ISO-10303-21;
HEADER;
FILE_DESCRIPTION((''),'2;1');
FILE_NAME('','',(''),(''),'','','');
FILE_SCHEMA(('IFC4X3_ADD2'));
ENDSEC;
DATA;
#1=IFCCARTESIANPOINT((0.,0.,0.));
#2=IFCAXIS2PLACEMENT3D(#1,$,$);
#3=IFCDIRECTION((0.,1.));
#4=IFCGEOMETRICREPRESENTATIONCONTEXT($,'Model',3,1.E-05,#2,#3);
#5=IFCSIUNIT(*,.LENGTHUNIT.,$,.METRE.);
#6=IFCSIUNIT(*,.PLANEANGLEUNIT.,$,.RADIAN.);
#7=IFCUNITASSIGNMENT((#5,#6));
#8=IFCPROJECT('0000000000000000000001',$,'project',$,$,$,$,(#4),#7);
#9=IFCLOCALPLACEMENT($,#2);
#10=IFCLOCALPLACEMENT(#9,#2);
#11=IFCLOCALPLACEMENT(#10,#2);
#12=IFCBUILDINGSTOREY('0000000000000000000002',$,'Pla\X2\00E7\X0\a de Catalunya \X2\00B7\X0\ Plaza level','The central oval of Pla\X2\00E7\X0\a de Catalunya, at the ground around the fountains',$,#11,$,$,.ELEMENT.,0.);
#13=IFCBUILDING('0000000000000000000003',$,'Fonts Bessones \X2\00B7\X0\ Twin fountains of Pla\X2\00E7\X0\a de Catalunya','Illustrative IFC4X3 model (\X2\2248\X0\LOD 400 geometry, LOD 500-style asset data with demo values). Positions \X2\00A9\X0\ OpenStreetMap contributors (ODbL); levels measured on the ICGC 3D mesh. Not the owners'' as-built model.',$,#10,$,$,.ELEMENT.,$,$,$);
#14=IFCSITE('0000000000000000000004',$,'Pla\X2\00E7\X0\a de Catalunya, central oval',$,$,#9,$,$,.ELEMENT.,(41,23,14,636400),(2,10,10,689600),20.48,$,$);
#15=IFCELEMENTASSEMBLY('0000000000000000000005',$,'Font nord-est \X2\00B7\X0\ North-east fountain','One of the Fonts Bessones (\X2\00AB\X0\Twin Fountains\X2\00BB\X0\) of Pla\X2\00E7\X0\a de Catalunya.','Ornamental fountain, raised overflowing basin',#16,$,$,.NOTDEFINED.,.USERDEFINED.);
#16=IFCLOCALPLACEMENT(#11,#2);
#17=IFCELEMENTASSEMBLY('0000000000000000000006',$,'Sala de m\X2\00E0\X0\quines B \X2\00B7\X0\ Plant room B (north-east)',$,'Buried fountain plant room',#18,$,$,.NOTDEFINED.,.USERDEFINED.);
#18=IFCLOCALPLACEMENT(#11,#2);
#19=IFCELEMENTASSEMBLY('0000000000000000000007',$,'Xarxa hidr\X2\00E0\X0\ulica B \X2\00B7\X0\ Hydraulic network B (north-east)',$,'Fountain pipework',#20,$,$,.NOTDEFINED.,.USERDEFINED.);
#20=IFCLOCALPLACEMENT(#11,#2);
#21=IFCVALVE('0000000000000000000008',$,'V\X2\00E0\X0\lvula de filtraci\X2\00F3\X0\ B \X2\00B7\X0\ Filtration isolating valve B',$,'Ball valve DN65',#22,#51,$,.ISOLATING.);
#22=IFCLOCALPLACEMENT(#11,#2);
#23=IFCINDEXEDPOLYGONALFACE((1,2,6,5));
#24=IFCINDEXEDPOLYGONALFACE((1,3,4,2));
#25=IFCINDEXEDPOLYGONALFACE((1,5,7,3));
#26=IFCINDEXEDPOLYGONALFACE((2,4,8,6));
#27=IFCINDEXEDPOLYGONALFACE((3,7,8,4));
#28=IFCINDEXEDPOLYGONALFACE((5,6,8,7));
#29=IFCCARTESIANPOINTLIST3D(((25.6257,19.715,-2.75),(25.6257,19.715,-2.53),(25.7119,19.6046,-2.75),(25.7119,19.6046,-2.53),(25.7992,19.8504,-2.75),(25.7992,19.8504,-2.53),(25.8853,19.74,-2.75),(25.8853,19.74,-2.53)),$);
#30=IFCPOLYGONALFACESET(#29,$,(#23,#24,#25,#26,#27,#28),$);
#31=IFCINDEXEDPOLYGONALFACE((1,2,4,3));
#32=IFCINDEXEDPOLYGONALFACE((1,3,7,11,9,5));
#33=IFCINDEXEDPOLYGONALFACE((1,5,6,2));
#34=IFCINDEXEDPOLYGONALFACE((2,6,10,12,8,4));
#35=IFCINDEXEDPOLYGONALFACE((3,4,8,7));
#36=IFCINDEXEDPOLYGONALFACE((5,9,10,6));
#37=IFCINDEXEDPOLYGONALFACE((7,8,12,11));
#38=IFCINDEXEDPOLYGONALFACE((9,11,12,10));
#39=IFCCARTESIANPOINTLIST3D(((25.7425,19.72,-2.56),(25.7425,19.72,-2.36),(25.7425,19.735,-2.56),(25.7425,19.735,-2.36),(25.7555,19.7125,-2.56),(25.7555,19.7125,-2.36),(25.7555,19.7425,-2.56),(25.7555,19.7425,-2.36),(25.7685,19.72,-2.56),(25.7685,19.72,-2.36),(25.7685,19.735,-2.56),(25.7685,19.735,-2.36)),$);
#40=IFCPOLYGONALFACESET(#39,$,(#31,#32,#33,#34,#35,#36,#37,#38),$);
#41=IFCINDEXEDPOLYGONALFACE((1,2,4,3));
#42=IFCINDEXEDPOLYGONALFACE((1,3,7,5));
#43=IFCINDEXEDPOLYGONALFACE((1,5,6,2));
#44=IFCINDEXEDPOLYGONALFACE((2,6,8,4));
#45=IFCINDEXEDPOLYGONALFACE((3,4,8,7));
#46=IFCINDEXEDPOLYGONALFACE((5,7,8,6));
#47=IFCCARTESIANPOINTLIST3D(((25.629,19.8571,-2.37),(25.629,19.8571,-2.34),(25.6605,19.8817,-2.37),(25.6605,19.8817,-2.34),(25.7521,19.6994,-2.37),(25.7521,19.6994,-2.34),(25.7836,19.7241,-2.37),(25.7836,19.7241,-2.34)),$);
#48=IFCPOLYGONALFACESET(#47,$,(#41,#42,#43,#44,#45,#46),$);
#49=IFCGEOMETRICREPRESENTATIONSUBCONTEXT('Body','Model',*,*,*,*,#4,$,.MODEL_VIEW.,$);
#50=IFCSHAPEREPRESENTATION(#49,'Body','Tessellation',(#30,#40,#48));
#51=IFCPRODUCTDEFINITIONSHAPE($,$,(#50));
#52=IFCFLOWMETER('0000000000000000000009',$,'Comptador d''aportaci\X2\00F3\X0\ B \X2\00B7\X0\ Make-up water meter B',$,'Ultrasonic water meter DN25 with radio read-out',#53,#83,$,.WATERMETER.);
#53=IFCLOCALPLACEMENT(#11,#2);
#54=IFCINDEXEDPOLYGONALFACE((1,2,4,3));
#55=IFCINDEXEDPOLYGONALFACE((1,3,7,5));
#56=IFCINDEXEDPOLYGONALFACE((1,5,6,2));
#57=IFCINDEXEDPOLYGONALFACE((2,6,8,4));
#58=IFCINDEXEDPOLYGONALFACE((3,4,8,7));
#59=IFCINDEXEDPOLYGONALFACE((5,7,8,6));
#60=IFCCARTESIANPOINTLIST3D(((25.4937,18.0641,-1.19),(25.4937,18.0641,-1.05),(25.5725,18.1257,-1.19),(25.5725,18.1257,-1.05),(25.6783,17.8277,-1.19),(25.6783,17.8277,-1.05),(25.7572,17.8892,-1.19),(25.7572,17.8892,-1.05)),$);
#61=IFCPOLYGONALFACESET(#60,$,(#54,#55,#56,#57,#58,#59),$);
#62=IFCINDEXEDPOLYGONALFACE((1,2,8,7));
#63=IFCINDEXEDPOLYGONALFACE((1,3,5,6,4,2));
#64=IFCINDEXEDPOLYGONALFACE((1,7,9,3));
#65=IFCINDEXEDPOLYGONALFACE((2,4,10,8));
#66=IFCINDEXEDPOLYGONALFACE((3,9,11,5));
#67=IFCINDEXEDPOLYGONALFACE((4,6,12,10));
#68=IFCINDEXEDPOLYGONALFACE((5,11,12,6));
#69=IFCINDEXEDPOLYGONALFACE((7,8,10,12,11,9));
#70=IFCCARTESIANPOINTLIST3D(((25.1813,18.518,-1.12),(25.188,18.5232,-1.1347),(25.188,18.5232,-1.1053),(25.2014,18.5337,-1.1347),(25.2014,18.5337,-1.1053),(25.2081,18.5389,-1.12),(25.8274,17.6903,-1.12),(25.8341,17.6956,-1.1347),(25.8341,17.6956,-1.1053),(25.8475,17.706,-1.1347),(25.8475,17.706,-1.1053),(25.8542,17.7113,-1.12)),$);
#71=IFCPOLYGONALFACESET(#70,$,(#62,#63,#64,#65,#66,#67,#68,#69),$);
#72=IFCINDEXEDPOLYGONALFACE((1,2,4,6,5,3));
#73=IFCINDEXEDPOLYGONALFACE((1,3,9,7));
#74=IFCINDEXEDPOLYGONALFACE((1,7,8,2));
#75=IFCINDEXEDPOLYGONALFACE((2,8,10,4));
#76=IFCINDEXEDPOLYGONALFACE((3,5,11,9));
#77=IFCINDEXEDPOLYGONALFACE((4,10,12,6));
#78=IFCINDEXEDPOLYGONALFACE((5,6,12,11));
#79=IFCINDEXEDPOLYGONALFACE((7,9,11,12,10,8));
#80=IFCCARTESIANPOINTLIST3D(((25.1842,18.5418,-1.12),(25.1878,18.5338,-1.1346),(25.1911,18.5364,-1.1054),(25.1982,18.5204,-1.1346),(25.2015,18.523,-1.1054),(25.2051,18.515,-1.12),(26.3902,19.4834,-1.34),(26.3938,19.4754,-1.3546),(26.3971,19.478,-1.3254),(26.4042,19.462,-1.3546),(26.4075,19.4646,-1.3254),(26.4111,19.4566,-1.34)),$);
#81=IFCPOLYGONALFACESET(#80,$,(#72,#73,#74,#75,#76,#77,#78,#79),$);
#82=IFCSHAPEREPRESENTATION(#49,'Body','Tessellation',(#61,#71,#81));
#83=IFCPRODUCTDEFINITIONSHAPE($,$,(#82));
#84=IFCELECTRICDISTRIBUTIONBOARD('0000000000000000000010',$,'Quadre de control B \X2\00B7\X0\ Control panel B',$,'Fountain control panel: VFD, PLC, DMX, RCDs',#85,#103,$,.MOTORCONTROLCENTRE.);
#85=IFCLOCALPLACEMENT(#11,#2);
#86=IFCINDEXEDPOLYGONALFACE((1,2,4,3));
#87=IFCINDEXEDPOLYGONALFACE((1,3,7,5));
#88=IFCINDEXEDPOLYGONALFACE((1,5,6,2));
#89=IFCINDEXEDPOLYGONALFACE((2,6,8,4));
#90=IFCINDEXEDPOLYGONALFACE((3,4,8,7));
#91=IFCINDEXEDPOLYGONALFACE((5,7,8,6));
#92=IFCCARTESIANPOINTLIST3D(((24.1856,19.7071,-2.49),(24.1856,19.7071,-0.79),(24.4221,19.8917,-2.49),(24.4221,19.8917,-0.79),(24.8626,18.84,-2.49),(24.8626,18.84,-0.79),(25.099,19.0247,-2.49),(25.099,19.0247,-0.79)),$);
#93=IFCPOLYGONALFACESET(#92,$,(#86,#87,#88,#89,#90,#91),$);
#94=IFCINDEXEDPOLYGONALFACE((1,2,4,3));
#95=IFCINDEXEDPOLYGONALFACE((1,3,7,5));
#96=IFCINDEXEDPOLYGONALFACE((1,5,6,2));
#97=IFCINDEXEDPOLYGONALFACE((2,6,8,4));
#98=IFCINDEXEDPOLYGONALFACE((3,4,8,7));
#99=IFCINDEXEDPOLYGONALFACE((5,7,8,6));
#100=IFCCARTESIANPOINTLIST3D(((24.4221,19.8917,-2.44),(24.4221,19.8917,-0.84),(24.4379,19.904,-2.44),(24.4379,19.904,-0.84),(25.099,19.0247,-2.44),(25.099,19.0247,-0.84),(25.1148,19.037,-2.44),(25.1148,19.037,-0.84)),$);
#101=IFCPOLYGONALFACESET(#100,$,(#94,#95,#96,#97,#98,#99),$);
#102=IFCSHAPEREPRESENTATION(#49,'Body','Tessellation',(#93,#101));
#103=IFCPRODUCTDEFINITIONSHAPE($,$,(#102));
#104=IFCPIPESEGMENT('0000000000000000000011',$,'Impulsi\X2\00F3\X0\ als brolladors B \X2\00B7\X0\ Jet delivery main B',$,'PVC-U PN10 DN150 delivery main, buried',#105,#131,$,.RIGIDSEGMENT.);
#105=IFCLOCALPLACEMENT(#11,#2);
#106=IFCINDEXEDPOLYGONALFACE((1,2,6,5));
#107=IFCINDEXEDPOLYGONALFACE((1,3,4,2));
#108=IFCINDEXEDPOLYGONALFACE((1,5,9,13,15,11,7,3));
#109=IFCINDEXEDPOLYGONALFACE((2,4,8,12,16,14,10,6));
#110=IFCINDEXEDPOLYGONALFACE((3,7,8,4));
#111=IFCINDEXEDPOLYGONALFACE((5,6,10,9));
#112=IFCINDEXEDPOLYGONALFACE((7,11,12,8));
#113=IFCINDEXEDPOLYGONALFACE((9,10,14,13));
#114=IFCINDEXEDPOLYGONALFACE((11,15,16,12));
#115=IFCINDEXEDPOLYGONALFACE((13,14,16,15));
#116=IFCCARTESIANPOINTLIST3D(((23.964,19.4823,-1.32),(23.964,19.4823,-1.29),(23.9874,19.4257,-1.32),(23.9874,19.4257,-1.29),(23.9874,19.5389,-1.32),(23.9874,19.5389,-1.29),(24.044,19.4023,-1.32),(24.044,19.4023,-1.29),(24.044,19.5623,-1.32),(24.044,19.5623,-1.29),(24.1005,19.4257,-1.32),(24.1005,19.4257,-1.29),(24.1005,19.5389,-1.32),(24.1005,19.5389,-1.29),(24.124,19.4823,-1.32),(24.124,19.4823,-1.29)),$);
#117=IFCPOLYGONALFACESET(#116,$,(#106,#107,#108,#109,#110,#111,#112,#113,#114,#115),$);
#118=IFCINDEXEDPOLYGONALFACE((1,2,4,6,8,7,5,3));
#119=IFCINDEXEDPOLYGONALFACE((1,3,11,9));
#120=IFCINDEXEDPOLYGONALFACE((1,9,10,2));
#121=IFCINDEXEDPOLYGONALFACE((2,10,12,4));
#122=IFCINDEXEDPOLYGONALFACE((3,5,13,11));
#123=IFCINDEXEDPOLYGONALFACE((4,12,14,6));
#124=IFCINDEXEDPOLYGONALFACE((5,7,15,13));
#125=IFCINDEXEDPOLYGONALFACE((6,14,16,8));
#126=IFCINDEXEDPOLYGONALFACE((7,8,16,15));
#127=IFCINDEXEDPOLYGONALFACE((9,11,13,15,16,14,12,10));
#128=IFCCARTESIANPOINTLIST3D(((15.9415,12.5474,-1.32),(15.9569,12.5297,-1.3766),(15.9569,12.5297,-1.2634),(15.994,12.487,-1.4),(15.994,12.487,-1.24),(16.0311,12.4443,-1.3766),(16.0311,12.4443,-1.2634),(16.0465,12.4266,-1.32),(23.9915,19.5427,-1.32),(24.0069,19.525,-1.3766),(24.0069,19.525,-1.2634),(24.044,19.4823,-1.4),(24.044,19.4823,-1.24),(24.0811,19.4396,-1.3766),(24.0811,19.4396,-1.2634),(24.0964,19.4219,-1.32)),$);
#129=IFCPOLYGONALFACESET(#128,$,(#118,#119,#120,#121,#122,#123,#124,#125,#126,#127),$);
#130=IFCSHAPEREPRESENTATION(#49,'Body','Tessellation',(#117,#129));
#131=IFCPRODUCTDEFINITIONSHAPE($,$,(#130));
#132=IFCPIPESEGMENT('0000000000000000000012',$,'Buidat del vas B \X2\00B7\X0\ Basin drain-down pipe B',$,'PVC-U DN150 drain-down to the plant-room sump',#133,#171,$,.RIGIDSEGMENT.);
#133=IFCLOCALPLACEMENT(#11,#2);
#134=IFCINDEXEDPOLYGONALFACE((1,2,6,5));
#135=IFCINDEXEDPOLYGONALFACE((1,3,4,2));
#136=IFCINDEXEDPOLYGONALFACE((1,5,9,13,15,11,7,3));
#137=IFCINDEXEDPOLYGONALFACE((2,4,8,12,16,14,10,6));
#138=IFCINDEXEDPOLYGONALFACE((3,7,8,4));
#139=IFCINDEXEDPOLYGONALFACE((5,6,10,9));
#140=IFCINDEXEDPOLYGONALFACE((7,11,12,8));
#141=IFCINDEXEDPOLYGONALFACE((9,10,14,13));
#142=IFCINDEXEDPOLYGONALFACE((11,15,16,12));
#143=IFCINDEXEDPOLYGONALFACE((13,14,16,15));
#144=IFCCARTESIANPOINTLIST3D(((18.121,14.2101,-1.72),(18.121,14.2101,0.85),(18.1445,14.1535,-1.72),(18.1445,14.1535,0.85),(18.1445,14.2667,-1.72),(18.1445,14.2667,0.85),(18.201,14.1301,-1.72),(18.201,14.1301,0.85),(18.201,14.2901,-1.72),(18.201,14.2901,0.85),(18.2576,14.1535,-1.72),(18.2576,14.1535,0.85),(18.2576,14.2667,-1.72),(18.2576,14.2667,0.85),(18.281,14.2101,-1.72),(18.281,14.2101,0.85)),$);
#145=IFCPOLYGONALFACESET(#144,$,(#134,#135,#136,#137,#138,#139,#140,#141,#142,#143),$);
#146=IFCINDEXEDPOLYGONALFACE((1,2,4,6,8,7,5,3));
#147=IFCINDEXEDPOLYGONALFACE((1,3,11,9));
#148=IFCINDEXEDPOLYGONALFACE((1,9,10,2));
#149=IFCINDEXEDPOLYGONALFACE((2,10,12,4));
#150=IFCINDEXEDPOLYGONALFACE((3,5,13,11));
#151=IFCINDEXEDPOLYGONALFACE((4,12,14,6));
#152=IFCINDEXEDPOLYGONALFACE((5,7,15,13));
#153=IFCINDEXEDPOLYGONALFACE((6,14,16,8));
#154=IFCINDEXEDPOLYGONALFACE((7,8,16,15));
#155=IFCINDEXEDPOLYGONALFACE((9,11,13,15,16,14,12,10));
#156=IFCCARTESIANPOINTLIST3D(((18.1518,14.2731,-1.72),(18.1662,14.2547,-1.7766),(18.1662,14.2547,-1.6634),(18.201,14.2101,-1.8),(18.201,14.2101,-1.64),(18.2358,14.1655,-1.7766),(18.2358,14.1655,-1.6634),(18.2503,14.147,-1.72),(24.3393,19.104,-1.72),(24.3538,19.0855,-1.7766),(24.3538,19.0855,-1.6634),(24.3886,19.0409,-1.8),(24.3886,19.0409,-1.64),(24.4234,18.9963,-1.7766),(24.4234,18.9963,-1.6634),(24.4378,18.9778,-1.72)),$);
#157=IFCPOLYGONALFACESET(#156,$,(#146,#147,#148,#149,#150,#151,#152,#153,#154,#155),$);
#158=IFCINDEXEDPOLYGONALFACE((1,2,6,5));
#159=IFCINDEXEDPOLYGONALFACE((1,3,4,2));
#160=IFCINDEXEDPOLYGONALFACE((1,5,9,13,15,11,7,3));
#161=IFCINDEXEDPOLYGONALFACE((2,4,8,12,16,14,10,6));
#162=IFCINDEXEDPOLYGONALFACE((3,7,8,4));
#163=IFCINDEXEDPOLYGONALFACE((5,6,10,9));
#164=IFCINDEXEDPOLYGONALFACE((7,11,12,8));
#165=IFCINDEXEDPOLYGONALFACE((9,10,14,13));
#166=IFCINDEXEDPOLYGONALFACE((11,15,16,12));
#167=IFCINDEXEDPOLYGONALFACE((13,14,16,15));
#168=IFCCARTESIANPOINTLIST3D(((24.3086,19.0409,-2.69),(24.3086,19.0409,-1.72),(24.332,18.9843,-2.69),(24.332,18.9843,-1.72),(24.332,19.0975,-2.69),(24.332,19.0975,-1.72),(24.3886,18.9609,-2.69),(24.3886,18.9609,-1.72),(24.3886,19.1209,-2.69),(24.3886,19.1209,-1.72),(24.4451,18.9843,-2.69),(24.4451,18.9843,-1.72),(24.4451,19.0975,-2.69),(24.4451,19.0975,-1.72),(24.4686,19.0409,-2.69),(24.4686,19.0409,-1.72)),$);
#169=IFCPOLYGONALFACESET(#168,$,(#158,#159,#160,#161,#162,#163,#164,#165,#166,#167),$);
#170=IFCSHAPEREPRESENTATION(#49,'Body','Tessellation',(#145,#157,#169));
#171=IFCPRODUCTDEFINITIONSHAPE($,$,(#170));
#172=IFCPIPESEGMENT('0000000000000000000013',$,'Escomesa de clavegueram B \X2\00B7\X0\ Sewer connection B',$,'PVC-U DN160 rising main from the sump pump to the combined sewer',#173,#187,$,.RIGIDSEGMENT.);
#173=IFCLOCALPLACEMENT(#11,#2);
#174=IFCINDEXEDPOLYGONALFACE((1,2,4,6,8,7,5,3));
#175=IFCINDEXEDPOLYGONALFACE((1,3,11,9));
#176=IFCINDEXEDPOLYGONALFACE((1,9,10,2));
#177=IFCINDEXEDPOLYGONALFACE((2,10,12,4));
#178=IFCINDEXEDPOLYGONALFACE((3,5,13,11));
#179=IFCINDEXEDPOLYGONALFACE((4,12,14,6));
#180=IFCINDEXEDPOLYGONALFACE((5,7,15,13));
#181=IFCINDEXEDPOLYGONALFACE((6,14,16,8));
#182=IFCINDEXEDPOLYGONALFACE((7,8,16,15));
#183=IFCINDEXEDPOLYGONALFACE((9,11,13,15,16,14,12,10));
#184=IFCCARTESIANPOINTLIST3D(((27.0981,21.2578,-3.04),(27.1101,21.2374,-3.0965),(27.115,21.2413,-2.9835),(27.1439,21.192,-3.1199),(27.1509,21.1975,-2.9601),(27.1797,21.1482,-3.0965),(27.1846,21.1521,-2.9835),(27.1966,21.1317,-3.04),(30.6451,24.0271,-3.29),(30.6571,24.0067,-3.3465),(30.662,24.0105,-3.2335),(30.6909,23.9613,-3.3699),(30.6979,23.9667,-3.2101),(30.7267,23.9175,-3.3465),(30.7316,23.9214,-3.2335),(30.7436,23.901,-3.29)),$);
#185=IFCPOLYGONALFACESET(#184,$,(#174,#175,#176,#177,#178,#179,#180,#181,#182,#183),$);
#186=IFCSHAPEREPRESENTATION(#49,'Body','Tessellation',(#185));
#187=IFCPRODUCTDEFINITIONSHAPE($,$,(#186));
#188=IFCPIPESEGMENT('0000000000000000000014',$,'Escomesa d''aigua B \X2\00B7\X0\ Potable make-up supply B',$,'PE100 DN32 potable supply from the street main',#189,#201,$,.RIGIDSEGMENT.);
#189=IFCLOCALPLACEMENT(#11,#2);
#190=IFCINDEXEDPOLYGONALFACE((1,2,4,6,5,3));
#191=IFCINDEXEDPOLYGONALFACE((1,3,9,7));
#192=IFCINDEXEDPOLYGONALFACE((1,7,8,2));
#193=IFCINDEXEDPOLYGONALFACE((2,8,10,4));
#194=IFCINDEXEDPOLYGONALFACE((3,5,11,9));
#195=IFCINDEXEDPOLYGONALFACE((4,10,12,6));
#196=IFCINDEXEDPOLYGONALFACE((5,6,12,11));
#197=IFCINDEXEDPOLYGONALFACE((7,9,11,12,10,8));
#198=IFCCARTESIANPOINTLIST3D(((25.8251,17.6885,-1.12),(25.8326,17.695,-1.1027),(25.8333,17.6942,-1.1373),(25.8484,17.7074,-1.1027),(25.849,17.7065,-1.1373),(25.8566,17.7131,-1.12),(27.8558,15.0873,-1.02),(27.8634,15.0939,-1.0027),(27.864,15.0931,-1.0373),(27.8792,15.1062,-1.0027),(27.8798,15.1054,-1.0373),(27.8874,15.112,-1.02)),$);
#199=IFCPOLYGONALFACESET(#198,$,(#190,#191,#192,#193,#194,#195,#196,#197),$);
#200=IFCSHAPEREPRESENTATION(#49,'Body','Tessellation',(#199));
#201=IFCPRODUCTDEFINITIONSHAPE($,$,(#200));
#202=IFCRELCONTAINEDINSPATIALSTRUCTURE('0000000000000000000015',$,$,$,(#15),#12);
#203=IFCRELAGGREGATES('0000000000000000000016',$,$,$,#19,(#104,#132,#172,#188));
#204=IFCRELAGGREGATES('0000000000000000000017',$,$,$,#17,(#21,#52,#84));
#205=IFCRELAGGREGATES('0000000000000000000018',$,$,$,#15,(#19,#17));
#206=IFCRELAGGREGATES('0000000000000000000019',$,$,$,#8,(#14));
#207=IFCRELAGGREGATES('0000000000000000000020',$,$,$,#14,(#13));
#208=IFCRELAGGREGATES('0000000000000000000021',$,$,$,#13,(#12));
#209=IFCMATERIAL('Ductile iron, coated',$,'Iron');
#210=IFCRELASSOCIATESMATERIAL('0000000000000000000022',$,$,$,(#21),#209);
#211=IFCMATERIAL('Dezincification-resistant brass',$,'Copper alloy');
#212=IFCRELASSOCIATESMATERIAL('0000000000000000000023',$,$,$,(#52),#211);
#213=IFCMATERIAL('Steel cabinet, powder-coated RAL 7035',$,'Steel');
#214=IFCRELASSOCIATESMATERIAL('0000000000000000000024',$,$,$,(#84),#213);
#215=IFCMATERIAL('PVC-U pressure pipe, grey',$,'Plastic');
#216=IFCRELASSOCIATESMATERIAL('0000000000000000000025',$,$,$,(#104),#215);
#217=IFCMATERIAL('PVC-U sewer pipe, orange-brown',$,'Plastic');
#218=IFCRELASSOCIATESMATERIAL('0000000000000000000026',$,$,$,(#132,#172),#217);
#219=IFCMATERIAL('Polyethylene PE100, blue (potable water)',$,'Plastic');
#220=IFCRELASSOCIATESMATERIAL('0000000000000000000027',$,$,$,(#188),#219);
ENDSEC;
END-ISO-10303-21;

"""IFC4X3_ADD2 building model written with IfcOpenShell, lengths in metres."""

from ifc_helpers import new_model, si_unit, direction, frame, frame_2d, origin, place, context, subcontext, project, spatial, polyline, rectangle, outline, extrude, material, element, aggregate, save


model = new_model("IFC4X3_ADD2")

# Units and contexts
model_context = context("Model", 3, precision=1e-05, world=origin(), true_north=direction((0.0, 1.0)))
body_context = subcontext(model_context, "Body", "Model", "MODEL_VIEW")
ifc_project = project(units=[si_unit("LENGTHUNIT", "METRE"), si_unit("PLANEANGLEUNIT", "RADIAN")], contexts=[model_context])

# Site, building, storey
site_placement = place(None, origin())
site = spatial("IfcSite", under=ifc_project, at=site_placement, Name="Plaça de Catalunya, central oval", CompositionType="ELEMENT", RefLatitude=(41, 23, 14, 636400), RefLongitude=(2, 10, 10, 689600), RefElevation=20.48)
building_placement = place(site_placement, origin())
building = spatial("IfcBuilding", under=site, at=building_placement, Name="Fonts Bessones · Twin fountains of Plaça de Catalunya", Description="Illustrative IFC4X3 model (≈LOD 400 geometry, LOD 500-style asset data with demo values). Positions © OpenStreetMap contributors (ODbL); levels measured on the ICGC 3D mesh. Not the owners' as-built model.", CompositionType="ELEMENT")
storey_placement = place(building_placement, origin())
storey = spatial("IfcBuildingStorey", under=building, at=storey_placement, Name="Plaça de Catalunya · Plaza level", Description="The central oval of Plaça de Catalunya, at the ground around the fountains", CompositionType="ELEMENT", Elevation=0.0)

# Element assemblies
assembly_1_placement = place(building_placement, origin())
assembly_1 = element("IfcElementAssembly", 1, at=assembly_1_placement, inside=storey, Name="Font nord-est · North-east fountain", Description="One of the Fonts Bessones («Twin Fountains») of Plaça de Catalunya.", ObjectType="Ornamental fountain, raised overflowing basin", AssemblyPlace="NOTDEFINED", PredefinedType="USERDEFINED")
assembly_2_placement = place(building_placement, origin())
assembly_2 = element("IfcElementAssembly", 2, at=assembly_2_placement, Name="Sala de màquines B · Plant room B (north-east)", ObjectType="Buried fountain plant room", AssemblyPlace="NOTDEFINED", PredefinedType="USERDEFINED")

# Element assembly
assembly_3_placement = place(building_placement, origin())
assembly_3 = element("IfcElementAssembly", 3, at=assembly_3_placement, Name="Xarxa hidràulica B · Hydraulic network B (north-east)", ObjectType="Fountain pipework", AssemblyPlace="NOTDEFINED", PredefinedType="USERDEFINED")

# Shared definitions
ifc_material_1 = material(Name="PVC-U pressure pipe, grey", Category="Plastic")

# Valve
ifc_material_2 = material(Name="Ductile iron, coated", Category="Iron")
valve_1_placement = place(building_placement, origin())
valve_1 = element("IfcValve", 4, at=valve_1_placement, material=ifc_material_2, Name="Vàlvula de filtració B · Filtration isolating valve B", ObjectType="Ball valve DN65", PredefinedType="ISOLATING", context=body_context, shape_type="SweptSolid", body=[
    extrude(rectangle(XDim=0.14, YDim=0.22, at=frame_2d((0.0, 0.0), x_axis=(-0.61539, 0.788223))), frame((25.7555, 19.7275, -2.75)), (0.0, 0.0, 1.0), 0.22),
    extrude(outline(polyline([(0.015, 0.0), (0.0075, 0.013), (-0.0075, 0.013), (-0.015, 0.0), (-0.0075, -0.013), (0.0075, -0.013), (0.015, 0.0)])), frame((25.7555, 19.7275, -2.56), z_axis=(0.0, 0.0, 1.0), x_axis=(0.0, 1.0, 0.0)), (0.0, 0.0, 1.0), 0.2),
    extrude(rectangle(XDim=0.2, YDim=0.04, at=frame_2d((0.0, 0.0), x_axis=(-0.61539, 0.788223))), frame((25.7063, 19.7906, -2.37)), (0.0, 0.0, 1.0), 0.03),
])

# Flow meter
ifc_material_3 = material(Name="Dezincification-resistant brass", Category="Copper alloy")
flow_meter_placement = place(building_placement, origin())
flow_meter = element("IfcFlowMeter", 5, at=flow_meter_placement, material=ifc_material_3, Name="Comptador d'aportació B · Make-up water meter B", ObjectType="Ultrasonic water meter DN25 with radio read-out", PredefinedType="WATERMETER", context=body_context, shape_type="SweptSolid", body=[
    extrude(rectangle(XDim=0.3, YDim=0.1, at=frame_2d((0.0, 0.0), x_axis=(-0.61539, 0.788223))), frame((25.6254, 17.9767, -1.19)), (0.0, 0.0, 1.0), 0.14),
    extrude(outline(polyline([(0.017, 0.0), (0.0085, 0.0147), (-0.0085, 0.0147), (-0.017, 0.0), (-0.0085, -0.0147), (0.0085, -0.0147), (0.017, 0.0)])), frame((25.8408, 17.7008, -1.12), z_axis=(-0.61539, 0.788223, 0.0), x_axis=(0.788223, 0.61539, 0.0)), (0.0, 0.0, 1.0), 1.05),
    extrude(outline(polyline([(0.017, 0.0), (0.0085, 0.0147), (-0.0085, 0.0147), (-0.017, 0.0), (-0.0085, -0.0147), (0.0085, -0.0147), (0.017, 0.0)])), frame((25.1947, 18.5284, -1.12), z_axis=(0.780199, 0.609125, -0.142327), x_axis=(0.61539, -0.788223, 0.0)), (0.0, 0.0, 1.0), 1.5457),
])

# Electric distribution board
ifc_material_4 = material(Name="Steel cabinet, powder-coated RAL 7035", Category="Steel")
electric_distribution_board_placement = place(building_placement, origin())
electric_distribution_board = element("IfcElectricDistributionBoard", 6, at=electric_distribution_board_placement, material=ifc_material_4, Name="Quadre de control B · Control panel B", ObjectType="Fountain control panel: VFD, PLC, DMX, RCDs", PredefinedType="MOTORCONTROLCENTRE", context=body_context, shape_type="SweptSolid", body=[
    extrude(rectangle(XDim=1.1, YDim=0.3, at=frame_2d((0.0, 0.0), x_axis=(-0.61539, 0.788223))), frame((24.6423, 19.3659, -2.49)), (0.0, 0.0, 1.0), 1.7),
    extrude(rectangle(XDim=1.1, YDim=0.02, at=frame_2d((0.0, 0.0), x_axis=(-0.61539, 0.788223))), frame((24.7684, 19.4643, -2.44)), (0.0, 0.0, 1.0), 1.6),
])

# Pipe segments
pipe_segment_1_placement = place(building_placement, origin())
pipe_segment_1 = element("IfcPipeSegment", 7, at=pipe_segment_1_placement, material=ifc_material_1, Name="Impulsió als brolladors B · Jet delivery main B", ObjectType="PVC-U PN10 DN150 delivery main, buried", PredefinedType="RIGIDSEGMENT", context=body_context, shape_type="SweptSolid", body=[
    extrude(outline(polyline([(0.08, 0.0), (0.0566, 0.0566), (0.0, 0.08), (-0.0566, 0.0566), (-0.08, 0.0), (-0.0566, -0.0566), (0.0, -0.08), (0.0566, -0.0566), (0.08, 0.0)])), frame((24.044, 19.4823, -1.29), z_axis=(0.0, 0.0, -1.0), x_axis=(0.0, -1.0, 0.0)), (0.0, 0.0, 1.0), 0.03),
    extrude(outline(polyline([(0.08, 0.0), (0.0566, 0.0566), (0.0, 0.08), (-0.0566, 0.0566), (-0.08, 0.0), (-0.0566, -0.0566), (0.0, -0.08), (0.0566, -0.0566), (0.08, 0.0)])), frame((24.044, 19.4823, -1.32), z_axis=(-0.754822, -0.65593, 0.0), x_axis=(-0.65593, 0.754822, 0.0)), (0.0, 0.0, 1.0), 10.6647),
])
ifc_material_5 = material(Name="PVC-U sewer pipe, orange-brown", Category="Plastic")
pipe_segment_2_placement = place(building_placement, origin())
pipe_segment_2 = element("IfcPipeSegment", 8, at=pipe_segment_2_placement, material=ifc_material_5, Name="Buidat del vas B · Basin drain-down pipe B", ObjectType="PVC-U DN150 drain-down to the plant-room sump", PredefinedType="RIGIDSEGMENT", context=body_context, shape_type="SweptSolid", body=[
    extrude(outline(polyline([(0.08, 0.0), (0.0566, 0.0566), (0.0, 0.08), (-0.0566, 0.0566), (-0.08, 0.0), (-0.0566, -0.0566), (0.0, -0.08), (0.0566, -0.0566), (0.08, 0.0)])), frame((18.201, 14.2101, 0.85), z_axis=(0.0, 0.0, -1.0), x_axis=(0.0, -1.0, 0.0)), (0.0, 0.0, 1.0), 2.57),
    extrude(outline(polyline([(0.08, 0.0), (0.0566, 0.0566), (0.0, 0.08), (-0.0566, 0.0566), (-0.08, 0.0), (-0.0566, -0.0566), (0.0, -0.08), (0.0566, -0.0566), (0.08, 0.0)])), frame((18.201, 14.2101, -1.72), z_axis=(0.788223, 0.61539, 0.0), x_axis=(0.61539, -0.788223, 0.0)), (0.0, 0.0, 1.0), 7.85),
    extrude(outline(polyline([(0.08, 0.0), (0.0566, 0.0566), (0.0, 0.08), (-0.0566, 0.0566), (-0.08, 0.0), (-0.0566, -0.0566), (0.0, -0.08), (0.0566, -0.0566), (0.08, 0.0)])), frame((24.3886, 19.0409, -1.72), z_axis=(0.0, 0.0, -1.0), x_axis=(0.0, -1.0, 0.0)), (0.0, 0.0, 1.0), 0.97),
])
pipe_segment_3_placement = place(building_placement, origin())
pipe_segment_3 = element("IfcPipeSegment", 9, at=pipe_segment_3_placement, material=ifc_material_5, Name="Escomesa de clavegueram B · Sewer connection B", ObjectType="PVC-U DN160 rising main from the sump pump to the combined sewer", PredefinedType="RIGIDSEGMENT", context=body_context, shape_type="SweptSolid", body=[
    extrude(outline(polyline([(0.08, 0.0), (0.0566, 0.0566), (0.0, 0.08), (-0.0566, 0.0566), (-0.08, 0.0), (-0.0566, -0.0566), (0.0, -0.08), (0.0566, -0.0566), (0.08, 0.0)])), frame((27.1474, 21.1948, -3.04), z_axis=(0.787009, 0.614442, -0.05547), x_axis=(0.61539, -0.788223, 0.0)), (0.0, 0.0, 1.0), 4.5069),
])
ifc_material_6 = material(Name="Polyethylene PE100, blue (potable water)", Category="Plastic")
pipe_segment_4_placement = place(building_placement, origin())
pipe_segment_4 = element("IfcPipeSegment", 10, at=pipe_segment_4_placement, material=ifc_material_6, Name="Escomesa d'aigua B · Potable make-up supply B", ObjectType="PE100 DN32 potable supply from the street main", PredefinedType="RIGIDSEGMENT", context=body_context, shape_type="SweptSolid", body=[
    extrude(outline(polyline([(0.02, 0.0), (0.01, 0.0173), (-0.01, 0.0173), (-0.02, 0.0), (-0.01, -0.0173), (0.01, -0.0173), (0.02, 0.0)])), frame((25.8408, 17.7008, -1.12), z_axis=(0.615107, -0.787861, 0.030289), x_axis=(-0.788223, -0.61539, 0.0)), (0.0, 0.0, 1.0), 3.3015),
])
aggregate(assembly_3, [pipe_segment_1, pipe_segment_2, pipe_segment_3, pipe_segment_4])

aggregate(assembly_2, [valve_1, flow_meter, electric_distribution_board])

aggregate(assembly_1, [assembly_3, assembly_2])

save(model, "model.ifc")
